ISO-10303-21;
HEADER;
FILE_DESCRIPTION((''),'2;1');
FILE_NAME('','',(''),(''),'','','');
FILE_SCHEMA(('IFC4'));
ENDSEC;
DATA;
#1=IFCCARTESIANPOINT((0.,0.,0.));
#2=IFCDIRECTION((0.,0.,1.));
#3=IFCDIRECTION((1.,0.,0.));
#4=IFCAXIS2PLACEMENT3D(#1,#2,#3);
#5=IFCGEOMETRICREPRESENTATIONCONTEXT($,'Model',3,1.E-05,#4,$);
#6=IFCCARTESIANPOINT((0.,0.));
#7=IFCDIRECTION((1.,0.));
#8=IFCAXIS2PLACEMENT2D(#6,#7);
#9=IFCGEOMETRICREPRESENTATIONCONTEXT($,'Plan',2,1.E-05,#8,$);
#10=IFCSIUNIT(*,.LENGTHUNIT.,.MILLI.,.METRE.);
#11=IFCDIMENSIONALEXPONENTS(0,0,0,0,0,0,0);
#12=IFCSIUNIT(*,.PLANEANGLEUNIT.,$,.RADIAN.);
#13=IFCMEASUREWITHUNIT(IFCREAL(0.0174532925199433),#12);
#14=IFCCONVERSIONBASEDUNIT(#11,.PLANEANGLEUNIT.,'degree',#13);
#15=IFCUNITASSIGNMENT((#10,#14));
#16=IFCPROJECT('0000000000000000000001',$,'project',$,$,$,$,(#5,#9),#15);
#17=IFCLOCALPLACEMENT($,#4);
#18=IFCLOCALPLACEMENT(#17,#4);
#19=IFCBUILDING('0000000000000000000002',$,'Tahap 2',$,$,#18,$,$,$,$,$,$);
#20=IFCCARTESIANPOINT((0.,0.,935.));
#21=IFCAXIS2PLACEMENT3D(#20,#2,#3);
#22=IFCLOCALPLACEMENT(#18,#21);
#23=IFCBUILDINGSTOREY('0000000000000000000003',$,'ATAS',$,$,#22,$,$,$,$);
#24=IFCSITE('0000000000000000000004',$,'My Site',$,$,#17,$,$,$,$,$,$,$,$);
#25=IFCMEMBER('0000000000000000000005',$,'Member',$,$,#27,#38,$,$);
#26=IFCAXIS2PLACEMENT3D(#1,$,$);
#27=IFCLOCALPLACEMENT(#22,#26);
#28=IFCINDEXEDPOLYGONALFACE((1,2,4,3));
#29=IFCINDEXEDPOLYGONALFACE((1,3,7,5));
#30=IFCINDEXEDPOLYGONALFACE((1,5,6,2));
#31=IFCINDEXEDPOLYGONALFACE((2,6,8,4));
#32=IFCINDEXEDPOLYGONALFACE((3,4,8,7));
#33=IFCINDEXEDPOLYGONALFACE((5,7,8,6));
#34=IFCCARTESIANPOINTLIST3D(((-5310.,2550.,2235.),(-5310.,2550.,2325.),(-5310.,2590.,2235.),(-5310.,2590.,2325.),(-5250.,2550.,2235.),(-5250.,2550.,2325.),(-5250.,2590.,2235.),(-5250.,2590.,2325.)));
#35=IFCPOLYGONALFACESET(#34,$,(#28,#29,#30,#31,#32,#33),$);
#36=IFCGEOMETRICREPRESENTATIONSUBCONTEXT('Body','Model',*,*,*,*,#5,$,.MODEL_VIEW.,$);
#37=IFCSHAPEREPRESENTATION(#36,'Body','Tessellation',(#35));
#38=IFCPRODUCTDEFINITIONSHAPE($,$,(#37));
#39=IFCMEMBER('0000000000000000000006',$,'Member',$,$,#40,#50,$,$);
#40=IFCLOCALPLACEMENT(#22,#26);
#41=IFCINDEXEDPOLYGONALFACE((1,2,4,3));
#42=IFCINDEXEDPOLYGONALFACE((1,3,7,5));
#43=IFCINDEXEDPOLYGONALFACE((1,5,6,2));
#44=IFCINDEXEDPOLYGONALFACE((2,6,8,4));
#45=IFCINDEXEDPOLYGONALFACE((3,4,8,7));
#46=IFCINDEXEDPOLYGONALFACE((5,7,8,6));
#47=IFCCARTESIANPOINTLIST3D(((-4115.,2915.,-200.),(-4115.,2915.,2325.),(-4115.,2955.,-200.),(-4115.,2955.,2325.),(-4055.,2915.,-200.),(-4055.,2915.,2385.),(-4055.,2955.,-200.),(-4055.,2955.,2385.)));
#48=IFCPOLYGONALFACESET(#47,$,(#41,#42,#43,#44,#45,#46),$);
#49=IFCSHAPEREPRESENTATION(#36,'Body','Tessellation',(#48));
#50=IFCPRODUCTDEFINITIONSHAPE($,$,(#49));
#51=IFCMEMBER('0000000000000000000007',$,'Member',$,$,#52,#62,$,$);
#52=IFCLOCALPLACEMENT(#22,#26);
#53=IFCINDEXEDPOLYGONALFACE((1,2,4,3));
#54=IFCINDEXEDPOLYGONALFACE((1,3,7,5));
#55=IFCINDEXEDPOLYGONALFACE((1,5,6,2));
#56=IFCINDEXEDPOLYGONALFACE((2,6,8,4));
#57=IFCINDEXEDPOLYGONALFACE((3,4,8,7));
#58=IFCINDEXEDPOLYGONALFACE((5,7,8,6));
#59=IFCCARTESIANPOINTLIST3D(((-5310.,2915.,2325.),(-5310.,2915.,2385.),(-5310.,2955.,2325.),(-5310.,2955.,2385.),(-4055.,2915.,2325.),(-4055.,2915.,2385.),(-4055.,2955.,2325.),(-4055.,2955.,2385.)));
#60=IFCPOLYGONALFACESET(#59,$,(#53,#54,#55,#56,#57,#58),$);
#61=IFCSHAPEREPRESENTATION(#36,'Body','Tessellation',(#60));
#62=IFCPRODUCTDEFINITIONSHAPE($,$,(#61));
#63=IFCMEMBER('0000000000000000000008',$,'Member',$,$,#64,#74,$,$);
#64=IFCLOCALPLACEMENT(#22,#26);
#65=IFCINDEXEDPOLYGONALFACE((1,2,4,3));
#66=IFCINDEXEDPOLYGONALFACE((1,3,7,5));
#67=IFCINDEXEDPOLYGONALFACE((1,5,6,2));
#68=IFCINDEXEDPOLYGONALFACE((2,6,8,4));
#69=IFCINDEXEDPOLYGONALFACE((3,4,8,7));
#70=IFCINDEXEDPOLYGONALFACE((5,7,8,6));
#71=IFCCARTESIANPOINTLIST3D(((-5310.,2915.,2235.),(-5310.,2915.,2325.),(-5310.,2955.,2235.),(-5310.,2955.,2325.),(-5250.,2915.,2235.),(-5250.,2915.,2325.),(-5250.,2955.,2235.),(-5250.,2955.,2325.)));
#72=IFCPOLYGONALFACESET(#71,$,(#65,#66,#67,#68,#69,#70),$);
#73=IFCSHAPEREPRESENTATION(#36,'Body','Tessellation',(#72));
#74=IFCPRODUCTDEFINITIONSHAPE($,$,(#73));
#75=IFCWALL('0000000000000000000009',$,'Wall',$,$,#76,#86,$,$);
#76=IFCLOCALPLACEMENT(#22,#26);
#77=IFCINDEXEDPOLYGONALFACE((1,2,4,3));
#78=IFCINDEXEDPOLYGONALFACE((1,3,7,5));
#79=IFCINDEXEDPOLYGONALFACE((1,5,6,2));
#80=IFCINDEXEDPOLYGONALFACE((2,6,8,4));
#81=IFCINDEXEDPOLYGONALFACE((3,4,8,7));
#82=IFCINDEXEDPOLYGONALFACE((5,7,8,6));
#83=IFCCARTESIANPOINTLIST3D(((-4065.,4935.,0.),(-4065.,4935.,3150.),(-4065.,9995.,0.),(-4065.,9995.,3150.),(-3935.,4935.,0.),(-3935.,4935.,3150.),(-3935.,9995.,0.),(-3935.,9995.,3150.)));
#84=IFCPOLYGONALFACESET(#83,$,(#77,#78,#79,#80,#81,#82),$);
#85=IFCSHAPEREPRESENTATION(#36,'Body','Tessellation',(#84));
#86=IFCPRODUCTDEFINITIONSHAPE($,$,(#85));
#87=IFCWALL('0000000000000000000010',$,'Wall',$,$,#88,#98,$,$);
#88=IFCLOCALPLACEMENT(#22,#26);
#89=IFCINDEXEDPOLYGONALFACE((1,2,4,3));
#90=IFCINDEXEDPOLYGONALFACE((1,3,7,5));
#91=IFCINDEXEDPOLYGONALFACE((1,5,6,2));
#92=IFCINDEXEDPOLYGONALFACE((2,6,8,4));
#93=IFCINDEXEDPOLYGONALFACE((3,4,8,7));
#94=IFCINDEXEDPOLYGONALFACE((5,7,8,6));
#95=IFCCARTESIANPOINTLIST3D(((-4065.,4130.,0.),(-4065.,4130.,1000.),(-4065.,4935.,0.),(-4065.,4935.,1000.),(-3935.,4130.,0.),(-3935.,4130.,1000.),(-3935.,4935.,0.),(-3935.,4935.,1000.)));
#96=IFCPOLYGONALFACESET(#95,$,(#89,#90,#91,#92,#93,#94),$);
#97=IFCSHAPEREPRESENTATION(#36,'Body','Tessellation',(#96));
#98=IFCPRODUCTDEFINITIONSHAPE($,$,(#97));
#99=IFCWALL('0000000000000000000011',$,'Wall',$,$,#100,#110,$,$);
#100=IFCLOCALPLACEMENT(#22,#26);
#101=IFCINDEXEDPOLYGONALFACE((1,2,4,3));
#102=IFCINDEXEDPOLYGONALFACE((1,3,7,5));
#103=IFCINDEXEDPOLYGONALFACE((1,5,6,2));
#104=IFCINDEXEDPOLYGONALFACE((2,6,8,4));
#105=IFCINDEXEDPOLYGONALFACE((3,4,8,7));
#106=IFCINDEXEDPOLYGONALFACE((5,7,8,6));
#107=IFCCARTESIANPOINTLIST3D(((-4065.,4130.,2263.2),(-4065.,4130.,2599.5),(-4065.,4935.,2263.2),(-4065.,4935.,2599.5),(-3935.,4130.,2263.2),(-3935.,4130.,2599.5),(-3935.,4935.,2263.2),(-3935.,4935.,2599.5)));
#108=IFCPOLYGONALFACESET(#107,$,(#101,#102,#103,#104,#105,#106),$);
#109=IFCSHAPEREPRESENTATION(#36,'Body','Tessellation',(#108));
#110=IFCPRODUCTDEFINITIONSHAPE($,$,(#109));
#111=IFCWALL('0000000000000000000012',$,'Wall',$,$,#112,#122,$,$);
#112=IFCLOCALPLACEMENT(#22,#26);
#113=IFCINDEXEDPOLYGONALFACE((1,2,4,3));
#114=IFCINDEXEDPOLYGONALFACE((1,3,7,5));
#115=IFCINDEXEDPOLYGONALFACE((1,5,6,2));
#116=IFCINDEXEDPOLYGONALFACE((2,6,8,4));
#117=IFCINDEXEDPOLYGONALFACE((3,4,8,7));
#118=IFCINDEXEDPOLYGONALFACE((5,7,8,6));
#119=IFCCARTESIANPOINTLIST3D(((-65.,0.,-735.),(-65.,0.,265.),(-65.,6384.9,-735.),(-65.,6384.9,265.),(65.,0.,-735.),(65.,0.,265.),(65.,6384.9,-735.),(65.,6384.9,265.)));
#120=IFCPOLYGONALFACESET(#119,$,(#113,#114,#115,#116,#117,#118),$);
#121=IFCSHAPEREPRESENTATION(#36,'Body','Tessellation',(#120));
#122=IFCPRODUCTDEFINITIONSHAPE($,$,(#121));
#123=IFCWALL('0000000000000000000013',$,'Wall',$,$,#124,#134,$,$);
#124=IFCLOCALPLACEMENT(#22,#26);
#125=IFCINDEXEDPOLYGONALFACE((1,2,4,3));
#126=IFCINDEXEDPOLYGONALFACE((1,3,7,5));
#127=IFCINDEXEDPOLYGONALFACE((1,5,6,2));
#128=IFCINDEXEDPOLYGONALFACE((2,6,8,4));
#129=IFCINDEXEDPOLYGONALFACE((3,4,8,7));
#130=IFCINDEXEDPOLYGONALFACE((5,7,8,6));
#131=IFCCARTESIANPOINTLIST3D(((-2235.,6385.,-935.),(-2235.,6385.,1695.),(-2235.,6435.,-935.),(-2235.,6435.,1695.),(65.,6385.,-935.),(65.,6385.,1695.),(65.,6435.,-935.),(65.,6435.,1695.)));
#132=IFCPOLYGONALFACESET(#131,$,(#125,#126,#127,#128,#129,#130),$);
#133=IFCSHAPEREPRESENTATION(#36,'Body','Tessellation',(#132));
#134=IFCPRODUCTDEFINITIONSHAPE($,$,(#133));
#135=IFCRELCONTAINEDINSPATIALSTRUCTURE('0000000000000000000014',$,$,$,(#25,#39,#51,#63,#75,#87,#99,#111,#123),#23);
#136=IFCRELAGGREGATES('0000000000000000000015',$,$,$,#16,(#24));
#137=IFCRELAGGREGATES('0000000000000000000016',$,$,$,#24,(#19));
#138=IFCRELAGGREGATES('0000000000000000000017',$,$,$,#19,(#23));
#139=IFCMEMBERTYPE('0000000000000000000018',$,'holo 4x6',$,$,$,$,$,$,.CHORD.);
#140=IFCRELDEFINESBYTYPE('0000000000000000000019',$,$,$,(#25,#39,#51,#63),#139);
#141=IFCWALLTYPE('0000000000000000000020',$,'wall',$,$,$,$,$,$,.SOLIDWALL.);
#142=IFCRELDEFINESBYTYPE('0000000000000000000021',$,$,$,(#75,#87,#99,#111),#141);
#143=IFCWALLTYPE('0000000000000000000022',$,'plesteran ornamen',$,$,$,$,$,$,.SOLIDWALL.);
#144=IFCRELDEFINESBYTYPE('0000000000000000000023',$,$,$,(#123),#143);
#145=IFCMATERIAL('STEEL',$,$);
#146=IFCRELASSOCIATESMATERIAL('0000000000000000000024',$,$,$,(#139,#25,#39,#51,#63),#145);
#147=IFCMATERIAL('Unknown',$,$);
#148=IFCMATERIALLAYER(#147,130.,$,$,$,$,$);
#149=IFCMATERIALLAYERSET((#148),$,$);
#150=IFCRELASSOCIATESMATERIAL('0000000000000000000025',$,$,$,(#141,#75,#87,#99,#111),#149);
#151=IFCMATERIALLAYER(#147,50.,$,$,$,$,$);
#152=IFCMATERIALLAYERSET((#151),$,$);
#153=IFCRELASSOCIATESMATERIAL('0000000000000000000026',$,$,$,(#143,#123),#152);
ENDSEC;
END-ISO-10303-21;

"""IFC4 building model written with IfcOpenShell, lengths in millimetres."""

from ifc_helpers import new_model, entity, si_unit, converted_unit, frame, origin_with_axes, origin_2d_with_axis, place, context, subcontext, project, spatial, line, indexed_curve, rectangle, outline, extrude, clip, halfspace, material, layer, layer_set, layer_usage, material_profile, profile_set, profile_usage, type_object, element, save


model = new_model("IFC4")

# Units and contexts
model_context = context("Model", 3, precision=1e-05, world=origin_with_axes())
plan_context = context("Plan", 2, precision=1e-05, world=origin_2d_with_axis())
body_context = subcontext(model_context, "Body", "Model", "MODEL_VIEW")
ifc_project = project(units=[si_unit("LENGTHUNIT", "METRE", prefix="MILLI"), converted_unit("PLANEANGLEUNIT", "degree", entity("IfcReal", 0.0174532925199433), si_unit("PLANEANGLEUNIT", "RADIAN"), dimensions=[0, 0, 0, 0, 0, 0, 0])], contexts=[model_context, plan_context])

# Site, building, storey
site_placement = place(None, origin_with_axes())
site = spatial("IfcSite", under=ifc_project, at=site_placement, Name="My Site")
building_placement = place(site_placement, origin_with_axes())
building = spatial("IfcBuilding", under=site, at=building_placement, Name="Tahap 2")
storey_placement = place(building_placement, frame((0.0, 0.0, 935.0), z_axis=(0.0, 0.0, 1.0), x_axis=(1.0, 0.0, 0.0)))
storey = spatial("IfcBuildingStorey", under=building, at=storey_placement, Name="ATAS")

# Members
ifc_material_1 = material(Name="STEEL")
ifc_material_profile_1 = material_profile(ifc_material_1, rectangle(XDim=40.0, YDim=60.0, kind="CURVE"))
ifc_profile_set_1 = profile_set([ifc_material_profile_1])
member_type_1 = type_object("IfcMemberType", Name="holo 4x6", PredefinedType="CHORD", material=ifc_profile_set_1)
ifc_profile_usage_1 = profile_usage(ifc_profile_set_1, cardinal=8)
member_1_placement = place(storey_placement, frame((-5250.0, 2570.0, 2235.0), z_axis=(0.0, 0.0, 1.0), x_axis=(0.0, -1.0, 0.0)))
element("IfcMember", 1, at=member_1_placement, inside=storey, type_object=member_type_1, material=ifc_profile_usage_1, Name="Member", context=body_context, shape_type="SweptSolid", body=[
    extrude(rectangle(XDim=40.0, YDim=60.0, kind="CURVE"), frame((0.0, -30.0, 0.0), z_axis=(0.0, 0.0, 1.0), x_axis=(1.0, 0.0, 0.0)), (0.0, 0.0, 1.0), 90.0),
])
ifc_profile_usage_2 = profile_usage(ifc_profile_set_1, cardinal=8)
member_2_placement = place(storey_placement, frame((-4055.0, 2935.0, -200.0), z_axis=(0.0, 0.0, 1.0), x_axis=(0.0, -1.0, 0.0)))
element("IfcMember", 2, at=member_2_placement, inside=storey, type_object=member_type_1, material=ifc_profile_usage_2, Name="Member", context=body_context, shape_type="Clipping", body=[
    clip(extrude(rectangle(XDim=40.0, YDim=60.0, kind="CURVE"), frame((0.0, -30.0, 0.0), z_axis=(0.0, 0.0, 1.0), x_axis=(1.0, 0.0, 0.0)), (0.0, 0.0, 1.0), 2585.0), halfspace(frame((550.0, 0.0, 2585.0), z_axis=(0.0, -0.707107, 0.707107), x_axis=(-1.0, 0.0, 0.0)), False)),
])
ifc_profile_usage_3 = profile_usage(ifc_profile_set_1, cardinal=8)
member_3_placement = place(storey_placement, frame((-4055.0, 2935.0, 2385.0), z_axis=(-1.0, 0.0, 0.0), x_axis=(0.0, -1.0, 0.0)))
element("IfcMember", 3, at=member_3_placement, inside=storey, type_object=member_type_1, material=ifc_profile_usage_3, Name="Member", context=body_context, shape_type="SweptSolid", body=[
    extrude(rectangle(XDim=40.0, YDim=60.0, kind="CURVE"), frame((0.0, -30.0, 0.0), z_axis=(0.0, 0.0, 1.0), x_axis=(1.0, 0.0, 0.0)), (0.0, 0.0, 1.0), 1255.0),
])
ifc_profile_usage_4 = profile_usage(ifc_profile_set_1, cardinal=8)
member_4_placement = place(storey_placement, frame((-5250.0, 2935.0, 2235.0), z_axis=(0.0, 0.0, 1.0), x_axis=(0.0, -1.0, 0.0)))
element("IfcMember", 4, at=member_4_placement, inside=storey, type_object=member_type_1, material=ifc_profile_usage_4, Name="Member", context=body_context, shape_type="SweptSolid", body=[
    extrude(rectangle(XDim=40.0, YDim=60.0, kind="CURVE"), frame((0.0, -30.0, 0.0), z_axis=(0.0, 0.0, 1.0), x_axis=(1.0, 0.0, 0.0)), (0.0, 0.0, 1.0), 90.0),
])

# Walls
ifc_material_2 = material(Name="Unknown")
ifc_layer_1 = layer(ifc_material_2, 130.0)
ifc_layer_set_1 = layer_set([ifc_layer_1])
ifc_layer_usage_1 = layer_usage(ifc_layer_set_1, "AXIS2", "POSITIVE", 0.0)
wall_type_1 = type_object("IfcWallType", Name="wall", PredefinedType="SOLIDWALL", material=ifc_layer_set_1)
wall_1_placement = place(storey_placement, frame((-3935.0, 4935.0, 0.0), z_axis=(0.0, 0.0, 1.0), x_axis=(0.0, 1.0, 0.0)))
element("IfcWall", 5, at=wall_1_placement, inside=storey, type_object=wall_type_1, material=ifc_layer_usage_1, Name="Wall", context=body_context, shape_type="SweptSolid", body=[
    extrude(outline(indexed_curve([(0.0, 0.0), (0.0, 130.0), (5060.0, 130.0), (5060.0, 0.0)], segments=[line(1, 2, 3, 4, 1)])), origin_with_axes(), (0.0, 0.0, 1.0), 3150.0),
])
ifc_layer_usage_2 = layer_usage(ifc_layer_set_1, "AXIS2", "NEGATIVE", 0.0)
wall_2_placement = place(storey_placement, frame((-3935.0, 4935.0, 0.0), z_axis=(0.0, 0.0, 1.0), x_axis=(-0.000001, -1.0, 0.0)))
element("IfcWall", 6, at=wall_2_placement, inside=storey, type_object=wall_type_1, material=ifc_layer_usage_2, Name="Wall", context=body_context, shape_type="SweptSolid", body=[
    extrude(outline(indexed_curve([(0.0, -130.0), (0.0, 0.0), (805.0, 0.0), (805.0, -130.0)], segments=[line(1, 2, 3, 4, 1)])), origin_with_axes(), (0.0, 0.0, 1.0), 1000.0),
])
ifc_layer_usage_3 = layer_usage(ifc_layer_set_1, "AXIS2", "NEGATIVE", 0.0)
wall_3_placement = place(storey_placement, frame((-3935.0, 4935.0, 2263.2), z_axis=(0.0, 0.0, 1.0), x_axis=(-0.000001, -1.0, 0.0)))
element("IfcWall", 7, at=wall_3_placement, inside=storey, type_object=wall_type_1, material=ifc_layer_usage_3, Name="Wall", context=body_context, shape_type="SweptSolid", body=[
    extrude(outline(indexed_curve([(0.0, -130.0), (0.0, 0.0), (805.0, 0.0), (805.0, -130.0)], segments=[line(1, 2, 3, 4, 1)])), origin_with_axes(), (0.0, 0.0, 1.0), 336.3),
])
ifc_layer_usage_4 = layer_usage(ifc_layer_set_1, "AXIS2", "NEGATIVE", 0.0)
wall_4_placement = place(storey_placement, frame((-65.0, 0.0, -735.0), z_axis=(0.0, 0.0, 1.0), x_axis=(0.0, 1.0, 0.0)))
element("IfcWall", 8, at=wall_4_placement, inside=storey, type_object=wall_type_1, material=ifc_layer_usage_4, Name="Wall", context=body_context, shape_type="SweptSolid", body=[
    extrude(outline(indexed_curve([(0.0, -130.0), (0.0, 0.0), (6384.9, 0.0), (6384.9, -130.0)], segments=[line(1, 2, 3, 4, 1)])), origin_with_axes(), (0.0, 0.0, 1.0), 1000.0),
])
ifc_layer_2 = layer(ifc_material_2, 50.0)
ifc_layer_set_2 = layer_set([ifc_layer_2])
ifc_layer_usage_5 = layer_usage(ifc_layer_set_2, "AXIS2", "NEGATIVE", 0.0)
wall_type_2 = type_object("IfcWallType", Name="plesteran ornamen", PredefinedType="SOLIDWALL", material=ifc_layer_set_2)
wall_5_placement = place(storey_placement, frame((-2235.0, 6435.0, -935.0), z_axis=(0.0, 0.0, 1.0), x_axis=(1.0, 0.0, 0.0)))
element("IfcWall", 9, at=wall_5_placement, inside=storey, type_object=wall_type_2, material=ifc_layer_usage_5, Name="Wall", context=body_context, shape_type="SweptSolid", body=[
    extrude(outline(indexed_curve([(0.0, -50.0), (0.0, 0.0), (2300.0, 0.0), (2300.0, -50.0)], segments=[line(1, 2, 3, 4, 1)])), origin_with_axes(), (0.0, 0.0, 1.0), 2630.0),
])

save(model, "model.ifc")
